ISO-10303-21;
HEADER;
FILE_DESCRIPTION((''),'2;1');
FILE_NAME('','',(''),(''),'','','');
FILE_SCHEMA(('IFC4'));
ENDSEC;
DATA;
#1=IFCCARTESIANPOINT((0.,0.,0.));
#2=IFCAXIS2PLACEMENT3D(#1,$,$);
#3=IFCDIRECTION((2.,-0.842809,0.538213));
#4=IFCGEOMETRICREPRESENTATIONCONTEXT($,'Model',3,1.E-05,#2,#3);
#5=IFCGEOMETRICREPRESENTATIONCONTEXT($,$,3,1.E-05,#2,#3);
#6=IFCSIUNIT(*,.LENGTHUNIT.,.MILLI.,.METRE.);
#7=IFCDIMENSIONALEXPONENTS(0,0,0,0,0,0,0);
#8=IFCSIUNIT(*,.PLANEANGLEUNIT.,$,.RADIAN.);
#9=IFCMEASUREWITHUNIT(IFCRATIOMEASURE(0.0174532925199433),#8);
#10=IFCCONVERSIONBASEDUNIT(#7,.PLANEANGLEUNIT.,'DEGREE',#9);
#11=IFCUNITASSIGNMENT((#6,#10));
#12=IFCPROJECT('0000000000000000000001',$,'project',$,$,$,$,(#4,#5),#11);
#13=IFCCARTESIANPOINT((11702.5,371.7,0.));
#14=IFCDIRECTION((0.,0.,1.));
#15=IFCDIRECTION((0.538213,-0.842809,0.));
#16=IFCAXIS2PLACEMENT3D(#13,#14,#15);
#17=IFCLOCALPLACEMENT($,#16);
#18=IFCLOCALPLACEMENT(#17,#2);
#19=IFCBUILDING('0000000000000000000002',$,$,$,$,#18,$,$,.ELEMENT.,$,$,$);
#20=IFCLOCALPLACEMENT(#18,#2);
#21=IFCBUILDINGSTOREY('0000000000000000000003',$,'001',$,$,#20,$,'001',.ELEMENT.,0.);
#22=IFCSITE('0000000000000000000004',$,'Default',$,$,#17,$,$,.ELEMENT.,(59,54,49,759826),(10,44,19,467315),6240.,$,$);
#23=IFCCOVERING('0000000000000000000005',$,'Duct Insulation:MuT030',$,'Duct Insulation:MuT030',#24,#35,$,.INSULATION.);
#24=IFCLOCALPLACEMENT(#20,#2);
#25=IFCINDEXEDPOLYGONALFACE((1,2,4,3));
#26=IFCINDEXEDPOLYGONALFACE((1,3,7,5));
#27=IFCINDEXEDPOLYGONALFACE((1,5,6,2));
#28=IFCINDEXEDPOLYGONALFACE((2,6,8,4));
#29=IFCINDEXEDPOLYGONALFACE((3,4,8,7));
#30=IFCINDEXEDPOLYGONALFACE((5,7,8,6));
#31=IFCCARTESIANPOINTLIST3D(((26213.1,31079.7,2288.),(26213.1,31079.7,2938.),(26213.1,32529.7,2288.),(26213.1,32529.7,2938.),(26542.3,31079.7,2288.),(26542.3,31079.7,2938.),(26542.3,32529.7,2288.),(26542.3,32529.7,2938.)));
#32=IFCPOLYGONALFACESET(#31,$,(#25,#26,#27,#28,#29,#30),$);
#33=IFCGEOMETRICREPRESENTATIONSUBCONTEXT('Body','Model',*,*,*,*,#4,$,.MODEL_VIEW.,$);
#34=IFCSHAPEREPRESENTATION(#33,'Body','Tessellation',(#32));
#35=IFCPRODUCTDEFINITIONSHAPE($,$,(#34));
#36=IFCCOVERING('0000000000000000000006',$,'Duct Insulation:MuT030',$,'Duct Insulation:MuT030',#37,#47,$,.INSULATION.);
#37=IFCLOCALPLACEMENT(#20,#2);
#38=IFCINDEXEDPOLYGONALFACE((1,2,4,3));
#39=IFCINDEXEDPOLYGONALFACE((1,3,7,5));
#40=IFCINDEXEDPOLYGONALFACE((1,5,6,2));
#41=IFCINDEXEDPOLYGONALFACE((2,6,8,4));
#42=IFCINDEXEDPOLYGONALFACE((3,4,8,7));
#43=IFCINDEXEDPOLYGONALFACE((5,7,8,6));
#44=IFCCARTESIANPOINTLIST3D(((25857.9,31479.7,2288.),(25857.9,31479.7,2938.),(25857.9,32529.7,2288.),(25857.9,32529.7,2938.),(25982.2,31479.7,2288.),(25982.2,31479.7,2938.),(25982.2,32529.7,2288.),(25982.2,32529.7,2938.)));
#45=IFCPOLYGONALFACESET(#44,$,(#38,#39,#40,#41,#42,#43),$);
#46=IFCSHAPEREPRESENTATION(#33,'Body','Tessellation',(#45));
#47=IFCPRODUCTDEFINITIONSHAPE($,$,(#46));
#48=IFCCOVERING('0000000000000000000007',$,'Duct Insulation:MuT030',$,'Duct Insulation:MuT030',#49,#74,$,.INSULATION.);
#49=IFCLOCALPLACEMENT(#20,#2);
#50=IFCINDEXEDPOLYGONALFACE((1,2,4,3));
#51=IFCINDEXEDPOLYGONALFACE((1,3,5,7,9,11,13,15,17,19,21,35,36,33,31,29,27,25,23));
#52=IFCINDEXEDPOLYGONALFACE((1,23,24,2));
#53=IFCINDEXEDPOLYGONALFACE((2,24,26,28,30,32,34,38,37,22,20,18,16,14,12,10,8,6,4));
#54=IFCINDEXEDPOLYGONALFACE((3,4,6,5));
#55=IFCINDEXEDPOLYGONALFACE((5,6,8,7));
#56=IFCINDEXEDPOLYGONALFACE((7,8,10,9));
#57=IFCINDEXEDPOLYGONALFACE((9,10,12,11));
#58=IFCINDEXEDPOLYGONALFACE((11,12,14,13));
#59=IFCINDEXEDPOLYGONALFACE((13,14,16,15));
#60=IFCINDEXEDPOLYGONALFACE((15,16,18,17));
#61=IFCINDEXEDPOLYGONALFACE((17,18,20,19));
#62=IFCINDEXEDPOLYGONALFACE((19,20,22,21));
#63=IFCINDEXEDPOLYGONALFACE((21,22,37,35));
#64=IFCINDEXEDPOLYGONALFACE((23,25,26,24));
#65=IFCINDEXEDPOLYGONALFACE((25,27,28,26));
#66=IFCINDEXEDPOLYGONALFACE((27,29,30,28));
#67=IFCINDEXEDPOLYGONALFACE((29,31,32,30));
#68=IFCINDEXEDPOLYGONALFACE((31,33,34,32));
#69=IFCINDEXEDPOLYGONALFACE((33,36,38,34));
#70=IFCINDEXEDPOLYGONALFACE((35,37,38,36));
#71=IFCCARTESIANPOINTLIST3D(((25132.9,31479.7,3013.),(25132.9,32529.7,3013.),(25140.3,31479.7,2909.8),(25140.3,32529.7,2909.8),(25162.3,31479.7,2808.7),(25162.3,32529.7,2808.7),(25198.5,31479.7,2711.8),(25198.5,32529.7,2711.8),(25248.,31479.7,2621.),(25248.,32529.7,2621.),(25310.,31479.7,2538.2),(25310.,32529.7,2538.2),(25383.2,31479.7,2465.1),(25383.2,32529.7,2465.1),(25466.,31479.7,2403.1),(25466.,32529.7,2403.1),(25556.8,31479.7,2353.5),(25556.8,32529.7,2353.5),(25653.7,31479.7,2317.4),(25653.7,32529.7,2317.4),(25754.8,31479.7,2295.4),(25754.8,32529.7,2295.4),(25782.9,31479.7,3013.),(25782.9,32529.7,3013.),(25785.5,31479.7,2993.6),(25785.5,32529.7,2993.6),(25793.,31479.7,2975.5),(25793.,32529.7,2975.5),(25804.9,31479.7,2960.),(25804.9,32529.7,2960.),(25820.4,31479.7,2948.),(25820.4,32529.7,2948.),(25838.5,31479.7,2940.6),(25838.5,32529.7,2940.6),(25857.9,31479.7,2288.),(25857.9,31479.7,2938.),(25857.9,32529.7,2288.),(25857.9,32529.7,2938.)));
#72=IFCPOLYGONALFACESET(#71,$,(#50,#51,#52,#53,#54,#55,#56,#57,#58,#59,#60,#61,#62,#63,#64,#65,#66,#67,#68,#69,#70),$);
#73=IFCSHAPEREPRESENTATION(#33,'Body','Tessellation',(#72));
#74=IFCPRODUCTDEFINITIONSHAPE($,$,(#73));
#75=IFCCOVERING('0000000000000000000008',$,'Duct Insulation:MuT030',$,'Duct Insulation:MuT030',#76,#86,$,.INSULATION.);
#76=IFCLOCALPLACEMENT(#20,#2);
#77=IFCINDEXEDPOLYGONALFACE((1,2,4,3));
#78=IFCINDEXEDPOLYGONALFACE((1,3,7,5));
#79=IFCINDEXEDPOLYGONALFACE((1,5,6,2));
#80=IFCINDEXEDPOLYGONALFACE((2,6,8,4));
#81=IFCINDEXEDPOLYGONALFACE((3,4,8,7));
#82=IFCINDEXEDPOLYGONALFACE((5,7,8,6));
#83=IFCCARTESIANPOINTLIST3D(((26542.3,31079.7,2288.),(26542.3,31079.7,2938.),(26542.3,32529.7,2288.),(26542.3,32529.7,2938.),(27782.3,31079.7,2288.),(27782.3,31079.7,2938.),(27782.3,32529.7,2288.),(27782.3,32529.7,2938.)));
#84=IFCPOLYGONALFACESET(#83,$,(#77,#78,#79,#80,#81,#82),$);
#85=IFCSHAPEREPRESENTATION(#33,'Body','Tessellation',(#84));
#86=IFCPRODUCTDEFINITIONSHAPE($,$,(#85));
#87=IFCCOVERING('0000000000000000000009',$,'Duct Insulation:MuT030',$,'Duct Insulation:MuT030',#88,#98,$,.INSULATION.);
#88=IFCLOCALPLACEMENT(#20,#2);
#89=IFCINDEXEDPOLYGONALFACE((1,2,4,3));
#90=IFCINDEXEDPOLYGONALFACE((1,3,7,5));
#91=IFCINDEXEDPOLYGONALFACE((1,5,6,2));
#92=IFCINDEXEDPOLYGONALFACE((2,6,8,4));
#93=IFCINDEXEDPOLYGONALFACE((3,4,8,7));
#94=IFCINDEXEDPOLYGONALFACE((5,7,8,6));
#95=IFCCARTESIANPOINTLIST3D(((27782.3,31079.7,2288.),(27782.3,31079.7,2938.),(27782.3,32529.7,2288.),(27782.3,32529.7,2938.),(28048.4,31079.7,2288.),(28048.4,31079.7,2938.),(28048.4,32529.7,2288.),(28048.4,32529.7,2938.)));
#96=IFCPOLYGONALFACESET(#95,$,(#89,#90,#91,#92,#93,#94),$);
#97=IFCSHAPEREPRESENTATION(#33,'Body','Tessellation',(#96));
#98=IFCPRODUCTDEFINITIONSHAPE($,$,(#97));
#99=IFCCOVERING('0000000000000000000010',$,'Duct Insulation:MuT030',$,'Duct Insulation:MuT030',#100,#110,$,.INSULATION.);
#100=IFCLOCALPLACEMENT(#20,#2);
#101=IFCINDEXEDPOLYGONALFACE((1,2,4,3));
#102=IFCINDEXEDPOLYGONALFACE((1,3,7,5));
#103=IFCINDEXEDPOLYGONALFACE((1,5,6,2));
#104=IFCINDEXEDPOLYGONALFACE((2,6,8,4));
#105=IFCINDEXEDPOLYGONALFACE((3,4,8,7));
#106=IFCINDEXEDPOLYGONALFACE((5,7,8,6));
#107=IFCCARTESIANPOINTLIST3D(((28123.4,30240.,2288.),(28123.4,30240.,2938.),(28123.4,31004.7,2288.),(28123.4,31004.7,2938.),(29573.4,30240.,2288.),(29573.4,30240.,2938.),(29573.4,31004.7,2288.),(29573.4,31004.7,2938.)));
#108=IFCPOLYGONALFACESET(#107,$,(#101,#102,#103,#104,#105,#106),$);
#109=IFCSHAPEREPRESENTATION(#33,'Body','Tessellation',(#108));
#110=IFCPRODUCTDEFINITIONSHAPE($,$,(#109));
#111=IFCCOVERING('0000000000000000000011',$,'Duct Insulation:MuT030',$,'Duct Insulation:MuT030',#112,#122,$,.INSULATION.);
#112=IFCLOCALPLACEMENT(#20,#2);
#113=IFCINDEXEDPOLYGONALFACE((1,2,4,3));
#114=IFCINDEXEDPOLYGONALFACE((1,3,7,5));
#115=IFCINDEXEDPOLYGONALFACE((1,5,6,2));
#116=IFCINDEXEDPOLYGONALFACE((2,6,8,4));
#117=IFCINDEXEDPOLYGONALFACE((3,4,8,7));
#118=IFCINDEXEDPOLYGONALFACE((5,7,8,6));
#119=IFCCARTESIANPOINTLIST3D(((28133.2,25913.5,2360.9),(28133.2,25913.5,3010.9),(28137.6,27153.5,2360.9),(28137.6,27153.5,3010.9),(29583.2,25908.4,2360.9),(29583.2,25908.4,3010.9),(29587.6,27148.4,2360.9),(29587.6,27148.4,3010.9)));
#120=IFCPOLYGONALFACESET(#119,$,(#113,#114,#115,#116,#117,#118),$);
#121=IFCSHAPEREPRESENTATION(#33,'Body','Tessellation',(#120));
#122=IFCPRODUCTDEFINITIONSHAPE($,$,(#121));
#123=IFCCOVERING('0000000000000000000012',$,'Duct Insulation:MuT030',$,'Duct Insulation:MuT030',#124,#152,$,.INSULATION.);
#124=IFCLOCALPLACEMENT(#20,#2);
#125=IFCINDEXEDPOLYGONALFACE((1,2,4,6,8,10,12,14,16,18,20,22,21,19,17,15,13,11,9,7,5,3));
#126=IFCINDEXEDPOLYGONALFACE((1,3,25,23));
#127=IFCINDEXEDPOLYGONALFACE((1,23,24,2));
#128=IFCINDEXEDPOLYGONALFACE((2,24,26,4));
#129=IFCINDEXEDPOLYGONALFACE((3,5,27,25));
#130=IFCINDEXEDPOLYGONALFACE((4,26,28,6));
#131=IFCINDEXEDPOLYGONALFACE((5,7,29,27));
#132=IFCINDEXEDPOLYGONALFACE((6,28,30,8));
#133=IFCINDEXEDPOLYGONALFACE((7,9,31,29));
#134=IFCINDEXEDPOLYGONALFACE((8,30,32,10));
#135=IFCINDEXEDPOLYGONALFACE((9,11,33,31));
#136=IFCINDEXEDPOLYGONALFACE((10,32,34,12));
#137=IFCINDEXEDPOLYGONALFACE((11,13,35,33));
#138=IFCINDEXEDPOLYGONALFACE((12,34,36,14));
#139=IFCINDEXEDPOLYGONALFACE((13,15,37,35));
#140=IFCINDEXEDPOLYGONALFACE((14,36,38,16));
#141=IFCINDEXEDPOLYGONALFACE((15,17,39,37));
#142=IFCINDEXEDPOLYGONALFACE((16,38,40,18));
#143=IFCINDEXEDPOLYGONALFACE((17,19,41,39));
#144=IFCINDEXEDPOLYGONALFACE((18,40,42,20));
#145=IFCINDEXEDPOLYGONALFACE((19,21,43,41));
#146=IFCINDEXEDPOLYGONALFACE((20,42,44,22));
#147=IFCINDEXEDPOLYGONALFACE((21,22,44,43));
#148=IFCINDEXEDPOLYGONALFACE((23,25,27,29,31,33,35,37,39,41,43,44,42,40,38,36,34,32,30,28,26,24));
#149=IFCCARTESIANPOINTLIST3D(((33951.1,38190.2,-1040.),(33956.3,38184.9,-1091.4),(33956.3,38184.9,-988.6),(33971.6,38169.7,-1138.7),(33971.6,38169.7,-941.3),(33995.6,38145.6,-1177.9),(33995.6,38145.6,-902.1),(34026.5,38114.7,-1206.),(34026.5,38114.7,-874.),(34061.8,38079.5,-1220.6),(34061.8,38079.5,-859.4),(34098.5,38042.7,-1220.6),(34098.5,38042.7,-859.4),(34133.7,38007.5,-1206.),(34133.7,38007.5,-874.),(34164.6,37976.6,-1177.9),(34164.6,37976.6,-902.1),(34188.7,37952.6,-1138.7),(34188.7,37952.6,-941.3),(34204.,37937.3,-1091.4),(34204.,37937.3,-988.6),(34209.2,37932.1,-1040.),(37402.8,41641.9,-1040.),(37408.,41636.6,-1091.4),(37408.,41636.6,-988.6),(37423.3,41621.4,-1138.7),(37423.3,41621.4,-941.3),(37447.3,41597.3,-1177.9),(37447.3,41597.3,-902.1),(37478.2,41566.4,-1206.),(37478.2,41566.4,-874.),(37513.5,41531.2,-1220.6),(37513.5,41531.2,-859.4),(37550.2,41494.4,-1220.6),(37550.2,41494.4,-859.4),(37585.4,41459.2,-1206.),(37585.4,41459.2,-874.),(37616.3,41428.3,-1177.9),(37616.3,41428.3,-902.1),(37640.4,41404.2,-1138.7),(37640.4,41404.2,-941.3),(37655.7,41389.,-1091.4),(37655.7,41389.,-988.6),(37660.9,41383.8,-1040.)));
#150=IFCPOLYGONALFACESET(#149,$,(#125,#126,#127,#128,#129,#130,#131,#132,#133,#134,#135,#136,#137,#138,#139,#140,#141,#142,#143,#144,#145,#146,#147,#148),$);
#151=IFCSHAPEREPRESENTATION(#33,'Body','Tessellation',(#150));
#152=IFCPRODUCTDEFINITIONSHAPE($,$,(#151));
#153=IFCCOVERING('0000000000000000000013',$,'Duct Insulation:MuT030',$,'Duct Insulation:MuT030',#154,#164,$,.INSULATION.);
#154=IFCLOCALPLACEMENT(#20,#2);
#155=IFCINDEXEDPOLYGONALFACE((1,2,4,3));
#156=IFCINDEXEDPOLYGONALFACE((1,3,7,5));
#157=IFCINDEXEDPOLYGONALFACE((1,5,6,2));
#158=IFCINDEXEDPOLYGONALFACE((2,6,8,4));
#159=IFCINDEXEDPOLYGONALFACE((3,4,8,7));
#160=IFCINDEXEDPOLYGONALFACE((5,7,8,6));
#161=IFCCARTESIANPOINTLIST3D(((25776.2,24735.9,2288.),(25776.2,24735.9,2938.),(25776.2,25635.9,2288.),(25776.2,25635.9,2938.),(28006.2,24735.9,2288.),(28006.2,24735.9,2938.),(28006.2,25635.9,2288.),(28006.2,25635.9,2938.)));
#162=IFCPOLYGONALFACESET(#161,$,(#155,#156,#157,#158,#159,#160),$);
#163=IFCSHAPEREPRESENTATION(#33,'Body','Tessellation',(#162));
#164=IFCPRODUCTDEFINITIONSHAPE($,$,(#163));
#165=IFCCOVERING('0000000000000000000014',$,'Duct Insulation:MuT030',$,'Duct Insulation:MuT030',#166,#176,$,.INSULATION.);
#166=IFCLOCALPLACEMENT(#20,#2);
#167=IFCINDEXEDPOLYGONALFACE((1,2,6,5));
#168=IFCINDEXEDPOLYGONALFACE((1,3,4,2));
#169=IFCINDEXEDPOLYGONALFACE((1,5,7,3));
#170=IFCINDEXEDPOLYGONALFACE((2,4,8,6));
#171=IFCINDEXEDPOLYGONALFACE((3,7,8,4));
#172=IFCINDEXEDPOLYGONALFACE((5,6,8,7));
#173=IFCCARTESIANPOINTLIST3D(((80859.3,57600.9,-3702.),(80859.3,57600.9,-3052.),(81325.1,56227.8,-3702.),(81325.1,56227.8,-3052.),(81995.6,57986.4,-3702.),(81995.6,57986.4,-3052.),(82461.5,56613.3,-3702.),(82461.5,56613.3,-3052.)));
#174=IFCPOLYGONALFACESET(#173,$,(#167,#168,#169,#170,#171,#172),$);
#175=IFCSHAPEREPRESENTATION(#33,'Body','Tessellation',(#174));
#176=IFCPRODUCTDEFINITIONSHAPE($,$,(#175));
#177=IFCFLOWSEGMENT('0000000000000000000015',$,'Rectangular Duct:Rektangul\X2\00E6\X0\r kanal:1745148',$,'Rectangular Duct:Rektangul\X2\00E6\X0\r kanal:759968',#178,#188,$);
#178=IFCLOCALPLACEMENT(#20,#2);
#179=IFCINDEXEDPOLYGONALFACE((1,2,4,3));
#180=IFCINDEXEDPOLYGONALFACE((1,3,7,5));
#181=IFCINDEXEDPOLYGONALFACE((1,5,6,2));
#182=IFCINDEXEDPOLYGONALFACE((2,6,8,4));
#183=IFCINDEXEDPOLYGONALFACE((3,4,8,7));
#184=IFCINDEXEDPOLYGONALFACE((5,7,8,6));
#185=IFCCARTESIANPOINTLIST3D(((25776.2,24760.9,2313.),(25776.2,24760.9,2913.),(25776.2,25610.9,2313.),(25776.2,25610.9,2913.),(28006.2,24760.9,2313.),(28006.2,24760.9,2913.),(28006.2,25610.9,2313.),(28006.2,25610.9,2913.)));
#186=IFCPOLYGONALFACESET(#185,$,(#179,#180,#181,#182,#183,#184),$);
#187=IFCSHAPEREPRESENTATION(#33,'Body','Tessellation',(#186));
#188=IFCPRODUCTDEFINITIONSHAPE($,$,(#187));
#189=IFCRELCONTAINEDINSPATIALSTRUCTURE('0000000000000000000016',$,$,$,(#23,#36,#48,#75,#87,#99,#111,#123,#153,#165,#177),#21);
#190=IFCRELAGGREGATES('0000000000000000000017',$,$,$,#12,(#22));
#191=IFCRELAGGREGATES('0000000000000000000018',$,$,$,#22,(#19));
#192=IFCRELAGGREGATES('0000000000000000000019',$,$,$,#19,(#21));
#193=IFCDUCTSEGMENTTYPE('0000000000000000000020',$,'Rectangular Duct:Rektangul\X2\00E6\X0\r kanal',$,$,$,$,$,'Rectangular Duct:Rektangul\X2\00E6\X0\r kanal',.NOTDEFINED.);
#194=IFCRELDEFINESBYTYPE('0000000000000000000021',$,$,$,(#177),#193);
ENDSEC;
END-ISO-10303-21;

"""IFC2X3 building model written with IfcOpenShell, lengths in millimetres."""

from ifc_helpers import new_model, entity, si_unit, converted_unit, direction, frame, frame_2d, origin, place, context, subcontext, project, spatial, polyline, circle_curve, parameter, trimmed, segment, composite_curve, rectangle, circle, outline, extrude, type_object, element, save


model = new_model("IFC2X3")

# Units and contexts
model_context = context("Model", 3, precision=1e-05, world=origin(), true_north=direction((2.0, -0.842809, 0.538213)))
context_of_model = context(None, 3, precision=1e-05, world=origin(), true_north=direction((2.0, -0.842809, 0.538213)))
body_context = subcontext(model_context, "Body", "Model", "MODEL_VIEW")
ifc_project = project(units=[si_unit("LENGTHUNIT", "METRE", prefix="MILLI"), converted_unit("PLANEANGLEUNIT", "DEGREE", entity("IfcRatioMeasure", 0.0174532925199433), si_unit("PLANEANGLEUNIT", "RADIAN"), dimensions=[0, 0, 0, 0, 0, 0, 0])], contexts=[model_context, context_of_model])

# Site, building, storey
site_placement = place(None, frame((11702.5, 371.7, 0.0), z_axis=(0.0, 0.0, 1.0), x_axis=(0.538213, -0.842809, 0.0)))
site = spatial("IfcSite", under=ifc_project, at=site_placement, Name="Default", CompositionType="ELEMENT", RefLatitude=(59, 54, 49, 759826), RefLongitude=(10, 44, 19, 467315), RefElevation=6240.0)
building_placement = place(site_placement, origin())
building = spatial("IfcBuilding", under=site, at=building_placement, CompositionType="ELEMENT")
storey_placement = place(building_placement, origin())
storey = spatial("IfcBuildingStorey", under=building, at=storey_placement, Name="001", LongName="001", CompositionType="ELEMENT", Elevation=0.0)

# Coverings
covering_1_placement = place(storey_placement, origin())
element("IfcCovering", 1, at=covering_1_placement, inside=storey, Name="Duct Insulation:MuT030", ObjectType="Duct Insulation:MuT030", PredefinedType="INSULATION", context=body_context, shape_type="SweptSolid", body=[
    extrude(rectangle(XDim=329.2, YDim=1450.0, at=frame_2d((0.0, 0.0), x_axis=(1.0, 0.0))), frame((26377.7, 31804.7, 2288.0), z_axis=(0.0, 0.0, 1.0), x_axis=(-1.0, 0.0, 0.0)), (0.0, 0.0, 1.0), 650.0),
])
covering_2_placement = place(storey_placement, origin())
element("IfcCovering", 2, at=covering_2_placement, inside=storey, Name="Duct Insulation:MuT030", ObjectType="Duct Insulation:MuT030", PredefinedType="INSULATION", context=body_context, shape_type="SweptSolid", body=[
    extrude(rectangle(XDim=124.2, YDim=1050.0, at=frame_2d((0.0, 0.0), x_axis=(1.0, 0.0))), frame((25920.1, 32004.7, 2288.0)), (0.0, 0.0, 1.0), 650.0),
])
covering_3_placement = place(storey_placement, origin())
element("IfcCovering", 3, at=covering_3_placement, inside=storey, Name="Duct Insulation:MuT030", ObjectType="Duct Insulation:MuT030", PredefinedType="INSULATION", context=body_context, shape_type="SweptSolid", body=[
    extrude(outline(composite_curve([segment(polyline([(-125.0, -200.0), (525.0, -200.0)]), True, "CONTINUOUS"), segment(trimmed(circle_curve(frame_2d((-200.0, -200.0), x_axis=(0.0, 1.0)), 725.0), [parameter(270.0)], [parameter(0.0)], True, "PARAMETER"), True, "CONTINUOUS"), segment(polyline([(-200.0, 525.0), (-200.0, -125.0)]), True, "CONTINUOUS"), segment(trimmed(circle_curve(frame_2d((-200.0, -200.0), x_axis=(0.0, 1.0)), 75.0), [parameter(270.0)], [parameter(360.0)], True, "PARAMETER"), False, "CONTINUOUS")], self_intersect=False)), frame((25657.9, 31479.7, 2813.0), z_axis=(0.0, 1.0, 0.0), x_axis=(0.0, 0.0, -1.0)), (0.0, 0.0, 1.0), 1050.0),
])
covering_4_placement = place(storey_placement, origin())
element("IfcCovering", 4, at=covering_4_placement, inside=storey, Name="Duct Insulation:MuT030", ObjectType="Duct Insulation:MuT030", PredefinedType="INSULATION", context=body_context, shape_type="SweptSolid", body=[
    extrude(rectangle(XDim=1240.0, YDim=1450.0, at=frame_2d((0.0, 0.0), x_axis=(1.0, 0.0))), frame((27162.3, 31804.7, 2288.0), z_axis=(0.0, 0.0, 1.0), x_axis=(-1.0, 0.0, 0.0)), (0.0, 0.0, 1.0), 650.0),
])
covering_5_placement = place(storey_placement, origin())
element("IfcCovering", 5, at=covering_5_placement, inside=storey, Name="Duct Insulation:MuT030", ObjectType="Duct Insulation:MuT030", PredefinedType="INSULATION", context=body_context, shape_type="SweptSolid", body=[
    extrude(rectangle(XDim=266.0, YDim=1450.0, at=frame_2d((0.0, 0.0), x_axis=(1.0, 0.0))), frame((27915.3, 31804.7, 2288.0), z_axis=(0.0, 0.0, 1.0), x_axis=(-1.0, 0.0, 0.0)), (0.0, 0.0, 1.0), 650.0),
])
covering_6_placement = place(storey_placement, origin())
element("IfcCovering", 6, at=covering_6_placement, inside=storey, Name="Duct Insulation:MuT030", ObjectType="Duct Insulation:MuT030", PredefinedType="INSULATION", context=body_context, shape_type="SweptSolid", body=[
    extrude(rectangle(XDim=764.7, YDim=1450.0, at=frame_2d((0.0, 0.0), x_axis=(1.0, 0.0))), frame((28848.4, 30622.3, 2288.0), z_axis=(0.0, 0.0, 1.0), x_axis=(0.0, -1.0, 0.0)), (0.0, 0.0, 1.0), 650.0),
])
covering_7_placement = place(storey_placement, origin())
element("IfcCovering", 7, at=covering_7_placement, inside=storey, Name="Duct Insulation:MuT030", ObjectType="Duct Insulation:MuT030", PredefinedType="INSULATION", context=body_context, shape_type="SweptSolid", body=[
    extrude(rectangle(XDim=1240.0, YDim=1450.0, at=frame_2d((0.0, 0.0), x_axis=(1.0, 0.0))), frame((28860.4, 26531.0, 2360.9), z_axis=(0.0, 0.0, 1.0), x_axis=(0.003502, 0.999994, 0.0)), (0.0, 0.0, 1.0), 650.0),
])
covering_8_placement = place(storey_placement, origin())
element("IfcCovering", 8, at=covering_8_placement, inside=storey, Name="Duct Insulation:MuT030", ObjectType="Duct Insulation:MuT030", PredefinedType="INSULATION", context=body_context, shape_type="SweptSolid", body=[
    extrude(circle(Radius=182.5, at=frame_2d((0.0, 0.0), x_axis=(1.0, 0.0))), frame((34080.1, 38061.1, -1040.0), z_axis=(0.707107, 0.707107, 0.0), x_axis=(0.707107, -0.707107, 0.0)), (0.0, 0.0, 1.0), 4881.4),
])
covering_9_placement = place(storey_placement, origin())
element("IfcCovering", 9, at=covering_9_placement, inside=storey, Name="Duct Insulation:MuT030", ObjectType="Duct Insulation:MuT030", PredefinedType="INSULATION", context=body_context, shape_type="SweptSolid", body=[
    extrude(rectangle(XDim=2230.0, YDim=900.0, at=frame_2d((0.0, 0.0), x_axis=(1.0, 0.0))), frame((26891.2, 25185.9, 2288.0)), (0.0, 0.0, 1.0), 650.0),
])
covering_10_placement = place(storey_placement, origin())
element("IfcCovering", 10, at=covering_10_placement, inside=storey, Name="Duct Insulation:MuT030", ObjectType="Duct Insulation:MuT030", PredefinedType="INSULATION", context=body_context, shape_type="SweptSolid", body=[
    extrude(rectangle(XDim=1200.0, YDim=1450.0, at=frame_2d((0.0, 0.0), x_axis=(1.0, 0.0))), frame((81660.4, 57107.1, -3702.0), z_axis=(0.0, 0.0, 1.0), x_axis=(-0.946982, -0.321288, 0.0)), (0.0, 0.0, 1.0), 650.0),
])

# Flow segment
duct_segment_type = type_object("IfcDuctSegmentType", Name="Rectangular Duct:Rektangulær kanal", ElementType="Rectangular Duct:Rektangulær kanal", PredefinedType="NOTDEFINED")
flow_segment_1_placement = place(storey_placement, origin())
element("IfcFlowSegment", 11, at=flow_segment_1_placement, inside=storey, type_object=duct_segment_type, Name="Rectangular Duct:Rektangulær kanal:1745148", ObjectType="Rectangular Duct:Rektangulær kanal:759968", context=body_context, shape_type="SweptSolid", body=[
    extrude(rectangle(XDim=2230.0, YDim=850.0, at=frame_2d((0.0, 0.0), x_axis=(1.0, 0.0))), frame((26891.2, 25185.9, 2313.0)), (0.0, 0.0, 1.0), 600.0),
])

save(model, "model.ifc")
